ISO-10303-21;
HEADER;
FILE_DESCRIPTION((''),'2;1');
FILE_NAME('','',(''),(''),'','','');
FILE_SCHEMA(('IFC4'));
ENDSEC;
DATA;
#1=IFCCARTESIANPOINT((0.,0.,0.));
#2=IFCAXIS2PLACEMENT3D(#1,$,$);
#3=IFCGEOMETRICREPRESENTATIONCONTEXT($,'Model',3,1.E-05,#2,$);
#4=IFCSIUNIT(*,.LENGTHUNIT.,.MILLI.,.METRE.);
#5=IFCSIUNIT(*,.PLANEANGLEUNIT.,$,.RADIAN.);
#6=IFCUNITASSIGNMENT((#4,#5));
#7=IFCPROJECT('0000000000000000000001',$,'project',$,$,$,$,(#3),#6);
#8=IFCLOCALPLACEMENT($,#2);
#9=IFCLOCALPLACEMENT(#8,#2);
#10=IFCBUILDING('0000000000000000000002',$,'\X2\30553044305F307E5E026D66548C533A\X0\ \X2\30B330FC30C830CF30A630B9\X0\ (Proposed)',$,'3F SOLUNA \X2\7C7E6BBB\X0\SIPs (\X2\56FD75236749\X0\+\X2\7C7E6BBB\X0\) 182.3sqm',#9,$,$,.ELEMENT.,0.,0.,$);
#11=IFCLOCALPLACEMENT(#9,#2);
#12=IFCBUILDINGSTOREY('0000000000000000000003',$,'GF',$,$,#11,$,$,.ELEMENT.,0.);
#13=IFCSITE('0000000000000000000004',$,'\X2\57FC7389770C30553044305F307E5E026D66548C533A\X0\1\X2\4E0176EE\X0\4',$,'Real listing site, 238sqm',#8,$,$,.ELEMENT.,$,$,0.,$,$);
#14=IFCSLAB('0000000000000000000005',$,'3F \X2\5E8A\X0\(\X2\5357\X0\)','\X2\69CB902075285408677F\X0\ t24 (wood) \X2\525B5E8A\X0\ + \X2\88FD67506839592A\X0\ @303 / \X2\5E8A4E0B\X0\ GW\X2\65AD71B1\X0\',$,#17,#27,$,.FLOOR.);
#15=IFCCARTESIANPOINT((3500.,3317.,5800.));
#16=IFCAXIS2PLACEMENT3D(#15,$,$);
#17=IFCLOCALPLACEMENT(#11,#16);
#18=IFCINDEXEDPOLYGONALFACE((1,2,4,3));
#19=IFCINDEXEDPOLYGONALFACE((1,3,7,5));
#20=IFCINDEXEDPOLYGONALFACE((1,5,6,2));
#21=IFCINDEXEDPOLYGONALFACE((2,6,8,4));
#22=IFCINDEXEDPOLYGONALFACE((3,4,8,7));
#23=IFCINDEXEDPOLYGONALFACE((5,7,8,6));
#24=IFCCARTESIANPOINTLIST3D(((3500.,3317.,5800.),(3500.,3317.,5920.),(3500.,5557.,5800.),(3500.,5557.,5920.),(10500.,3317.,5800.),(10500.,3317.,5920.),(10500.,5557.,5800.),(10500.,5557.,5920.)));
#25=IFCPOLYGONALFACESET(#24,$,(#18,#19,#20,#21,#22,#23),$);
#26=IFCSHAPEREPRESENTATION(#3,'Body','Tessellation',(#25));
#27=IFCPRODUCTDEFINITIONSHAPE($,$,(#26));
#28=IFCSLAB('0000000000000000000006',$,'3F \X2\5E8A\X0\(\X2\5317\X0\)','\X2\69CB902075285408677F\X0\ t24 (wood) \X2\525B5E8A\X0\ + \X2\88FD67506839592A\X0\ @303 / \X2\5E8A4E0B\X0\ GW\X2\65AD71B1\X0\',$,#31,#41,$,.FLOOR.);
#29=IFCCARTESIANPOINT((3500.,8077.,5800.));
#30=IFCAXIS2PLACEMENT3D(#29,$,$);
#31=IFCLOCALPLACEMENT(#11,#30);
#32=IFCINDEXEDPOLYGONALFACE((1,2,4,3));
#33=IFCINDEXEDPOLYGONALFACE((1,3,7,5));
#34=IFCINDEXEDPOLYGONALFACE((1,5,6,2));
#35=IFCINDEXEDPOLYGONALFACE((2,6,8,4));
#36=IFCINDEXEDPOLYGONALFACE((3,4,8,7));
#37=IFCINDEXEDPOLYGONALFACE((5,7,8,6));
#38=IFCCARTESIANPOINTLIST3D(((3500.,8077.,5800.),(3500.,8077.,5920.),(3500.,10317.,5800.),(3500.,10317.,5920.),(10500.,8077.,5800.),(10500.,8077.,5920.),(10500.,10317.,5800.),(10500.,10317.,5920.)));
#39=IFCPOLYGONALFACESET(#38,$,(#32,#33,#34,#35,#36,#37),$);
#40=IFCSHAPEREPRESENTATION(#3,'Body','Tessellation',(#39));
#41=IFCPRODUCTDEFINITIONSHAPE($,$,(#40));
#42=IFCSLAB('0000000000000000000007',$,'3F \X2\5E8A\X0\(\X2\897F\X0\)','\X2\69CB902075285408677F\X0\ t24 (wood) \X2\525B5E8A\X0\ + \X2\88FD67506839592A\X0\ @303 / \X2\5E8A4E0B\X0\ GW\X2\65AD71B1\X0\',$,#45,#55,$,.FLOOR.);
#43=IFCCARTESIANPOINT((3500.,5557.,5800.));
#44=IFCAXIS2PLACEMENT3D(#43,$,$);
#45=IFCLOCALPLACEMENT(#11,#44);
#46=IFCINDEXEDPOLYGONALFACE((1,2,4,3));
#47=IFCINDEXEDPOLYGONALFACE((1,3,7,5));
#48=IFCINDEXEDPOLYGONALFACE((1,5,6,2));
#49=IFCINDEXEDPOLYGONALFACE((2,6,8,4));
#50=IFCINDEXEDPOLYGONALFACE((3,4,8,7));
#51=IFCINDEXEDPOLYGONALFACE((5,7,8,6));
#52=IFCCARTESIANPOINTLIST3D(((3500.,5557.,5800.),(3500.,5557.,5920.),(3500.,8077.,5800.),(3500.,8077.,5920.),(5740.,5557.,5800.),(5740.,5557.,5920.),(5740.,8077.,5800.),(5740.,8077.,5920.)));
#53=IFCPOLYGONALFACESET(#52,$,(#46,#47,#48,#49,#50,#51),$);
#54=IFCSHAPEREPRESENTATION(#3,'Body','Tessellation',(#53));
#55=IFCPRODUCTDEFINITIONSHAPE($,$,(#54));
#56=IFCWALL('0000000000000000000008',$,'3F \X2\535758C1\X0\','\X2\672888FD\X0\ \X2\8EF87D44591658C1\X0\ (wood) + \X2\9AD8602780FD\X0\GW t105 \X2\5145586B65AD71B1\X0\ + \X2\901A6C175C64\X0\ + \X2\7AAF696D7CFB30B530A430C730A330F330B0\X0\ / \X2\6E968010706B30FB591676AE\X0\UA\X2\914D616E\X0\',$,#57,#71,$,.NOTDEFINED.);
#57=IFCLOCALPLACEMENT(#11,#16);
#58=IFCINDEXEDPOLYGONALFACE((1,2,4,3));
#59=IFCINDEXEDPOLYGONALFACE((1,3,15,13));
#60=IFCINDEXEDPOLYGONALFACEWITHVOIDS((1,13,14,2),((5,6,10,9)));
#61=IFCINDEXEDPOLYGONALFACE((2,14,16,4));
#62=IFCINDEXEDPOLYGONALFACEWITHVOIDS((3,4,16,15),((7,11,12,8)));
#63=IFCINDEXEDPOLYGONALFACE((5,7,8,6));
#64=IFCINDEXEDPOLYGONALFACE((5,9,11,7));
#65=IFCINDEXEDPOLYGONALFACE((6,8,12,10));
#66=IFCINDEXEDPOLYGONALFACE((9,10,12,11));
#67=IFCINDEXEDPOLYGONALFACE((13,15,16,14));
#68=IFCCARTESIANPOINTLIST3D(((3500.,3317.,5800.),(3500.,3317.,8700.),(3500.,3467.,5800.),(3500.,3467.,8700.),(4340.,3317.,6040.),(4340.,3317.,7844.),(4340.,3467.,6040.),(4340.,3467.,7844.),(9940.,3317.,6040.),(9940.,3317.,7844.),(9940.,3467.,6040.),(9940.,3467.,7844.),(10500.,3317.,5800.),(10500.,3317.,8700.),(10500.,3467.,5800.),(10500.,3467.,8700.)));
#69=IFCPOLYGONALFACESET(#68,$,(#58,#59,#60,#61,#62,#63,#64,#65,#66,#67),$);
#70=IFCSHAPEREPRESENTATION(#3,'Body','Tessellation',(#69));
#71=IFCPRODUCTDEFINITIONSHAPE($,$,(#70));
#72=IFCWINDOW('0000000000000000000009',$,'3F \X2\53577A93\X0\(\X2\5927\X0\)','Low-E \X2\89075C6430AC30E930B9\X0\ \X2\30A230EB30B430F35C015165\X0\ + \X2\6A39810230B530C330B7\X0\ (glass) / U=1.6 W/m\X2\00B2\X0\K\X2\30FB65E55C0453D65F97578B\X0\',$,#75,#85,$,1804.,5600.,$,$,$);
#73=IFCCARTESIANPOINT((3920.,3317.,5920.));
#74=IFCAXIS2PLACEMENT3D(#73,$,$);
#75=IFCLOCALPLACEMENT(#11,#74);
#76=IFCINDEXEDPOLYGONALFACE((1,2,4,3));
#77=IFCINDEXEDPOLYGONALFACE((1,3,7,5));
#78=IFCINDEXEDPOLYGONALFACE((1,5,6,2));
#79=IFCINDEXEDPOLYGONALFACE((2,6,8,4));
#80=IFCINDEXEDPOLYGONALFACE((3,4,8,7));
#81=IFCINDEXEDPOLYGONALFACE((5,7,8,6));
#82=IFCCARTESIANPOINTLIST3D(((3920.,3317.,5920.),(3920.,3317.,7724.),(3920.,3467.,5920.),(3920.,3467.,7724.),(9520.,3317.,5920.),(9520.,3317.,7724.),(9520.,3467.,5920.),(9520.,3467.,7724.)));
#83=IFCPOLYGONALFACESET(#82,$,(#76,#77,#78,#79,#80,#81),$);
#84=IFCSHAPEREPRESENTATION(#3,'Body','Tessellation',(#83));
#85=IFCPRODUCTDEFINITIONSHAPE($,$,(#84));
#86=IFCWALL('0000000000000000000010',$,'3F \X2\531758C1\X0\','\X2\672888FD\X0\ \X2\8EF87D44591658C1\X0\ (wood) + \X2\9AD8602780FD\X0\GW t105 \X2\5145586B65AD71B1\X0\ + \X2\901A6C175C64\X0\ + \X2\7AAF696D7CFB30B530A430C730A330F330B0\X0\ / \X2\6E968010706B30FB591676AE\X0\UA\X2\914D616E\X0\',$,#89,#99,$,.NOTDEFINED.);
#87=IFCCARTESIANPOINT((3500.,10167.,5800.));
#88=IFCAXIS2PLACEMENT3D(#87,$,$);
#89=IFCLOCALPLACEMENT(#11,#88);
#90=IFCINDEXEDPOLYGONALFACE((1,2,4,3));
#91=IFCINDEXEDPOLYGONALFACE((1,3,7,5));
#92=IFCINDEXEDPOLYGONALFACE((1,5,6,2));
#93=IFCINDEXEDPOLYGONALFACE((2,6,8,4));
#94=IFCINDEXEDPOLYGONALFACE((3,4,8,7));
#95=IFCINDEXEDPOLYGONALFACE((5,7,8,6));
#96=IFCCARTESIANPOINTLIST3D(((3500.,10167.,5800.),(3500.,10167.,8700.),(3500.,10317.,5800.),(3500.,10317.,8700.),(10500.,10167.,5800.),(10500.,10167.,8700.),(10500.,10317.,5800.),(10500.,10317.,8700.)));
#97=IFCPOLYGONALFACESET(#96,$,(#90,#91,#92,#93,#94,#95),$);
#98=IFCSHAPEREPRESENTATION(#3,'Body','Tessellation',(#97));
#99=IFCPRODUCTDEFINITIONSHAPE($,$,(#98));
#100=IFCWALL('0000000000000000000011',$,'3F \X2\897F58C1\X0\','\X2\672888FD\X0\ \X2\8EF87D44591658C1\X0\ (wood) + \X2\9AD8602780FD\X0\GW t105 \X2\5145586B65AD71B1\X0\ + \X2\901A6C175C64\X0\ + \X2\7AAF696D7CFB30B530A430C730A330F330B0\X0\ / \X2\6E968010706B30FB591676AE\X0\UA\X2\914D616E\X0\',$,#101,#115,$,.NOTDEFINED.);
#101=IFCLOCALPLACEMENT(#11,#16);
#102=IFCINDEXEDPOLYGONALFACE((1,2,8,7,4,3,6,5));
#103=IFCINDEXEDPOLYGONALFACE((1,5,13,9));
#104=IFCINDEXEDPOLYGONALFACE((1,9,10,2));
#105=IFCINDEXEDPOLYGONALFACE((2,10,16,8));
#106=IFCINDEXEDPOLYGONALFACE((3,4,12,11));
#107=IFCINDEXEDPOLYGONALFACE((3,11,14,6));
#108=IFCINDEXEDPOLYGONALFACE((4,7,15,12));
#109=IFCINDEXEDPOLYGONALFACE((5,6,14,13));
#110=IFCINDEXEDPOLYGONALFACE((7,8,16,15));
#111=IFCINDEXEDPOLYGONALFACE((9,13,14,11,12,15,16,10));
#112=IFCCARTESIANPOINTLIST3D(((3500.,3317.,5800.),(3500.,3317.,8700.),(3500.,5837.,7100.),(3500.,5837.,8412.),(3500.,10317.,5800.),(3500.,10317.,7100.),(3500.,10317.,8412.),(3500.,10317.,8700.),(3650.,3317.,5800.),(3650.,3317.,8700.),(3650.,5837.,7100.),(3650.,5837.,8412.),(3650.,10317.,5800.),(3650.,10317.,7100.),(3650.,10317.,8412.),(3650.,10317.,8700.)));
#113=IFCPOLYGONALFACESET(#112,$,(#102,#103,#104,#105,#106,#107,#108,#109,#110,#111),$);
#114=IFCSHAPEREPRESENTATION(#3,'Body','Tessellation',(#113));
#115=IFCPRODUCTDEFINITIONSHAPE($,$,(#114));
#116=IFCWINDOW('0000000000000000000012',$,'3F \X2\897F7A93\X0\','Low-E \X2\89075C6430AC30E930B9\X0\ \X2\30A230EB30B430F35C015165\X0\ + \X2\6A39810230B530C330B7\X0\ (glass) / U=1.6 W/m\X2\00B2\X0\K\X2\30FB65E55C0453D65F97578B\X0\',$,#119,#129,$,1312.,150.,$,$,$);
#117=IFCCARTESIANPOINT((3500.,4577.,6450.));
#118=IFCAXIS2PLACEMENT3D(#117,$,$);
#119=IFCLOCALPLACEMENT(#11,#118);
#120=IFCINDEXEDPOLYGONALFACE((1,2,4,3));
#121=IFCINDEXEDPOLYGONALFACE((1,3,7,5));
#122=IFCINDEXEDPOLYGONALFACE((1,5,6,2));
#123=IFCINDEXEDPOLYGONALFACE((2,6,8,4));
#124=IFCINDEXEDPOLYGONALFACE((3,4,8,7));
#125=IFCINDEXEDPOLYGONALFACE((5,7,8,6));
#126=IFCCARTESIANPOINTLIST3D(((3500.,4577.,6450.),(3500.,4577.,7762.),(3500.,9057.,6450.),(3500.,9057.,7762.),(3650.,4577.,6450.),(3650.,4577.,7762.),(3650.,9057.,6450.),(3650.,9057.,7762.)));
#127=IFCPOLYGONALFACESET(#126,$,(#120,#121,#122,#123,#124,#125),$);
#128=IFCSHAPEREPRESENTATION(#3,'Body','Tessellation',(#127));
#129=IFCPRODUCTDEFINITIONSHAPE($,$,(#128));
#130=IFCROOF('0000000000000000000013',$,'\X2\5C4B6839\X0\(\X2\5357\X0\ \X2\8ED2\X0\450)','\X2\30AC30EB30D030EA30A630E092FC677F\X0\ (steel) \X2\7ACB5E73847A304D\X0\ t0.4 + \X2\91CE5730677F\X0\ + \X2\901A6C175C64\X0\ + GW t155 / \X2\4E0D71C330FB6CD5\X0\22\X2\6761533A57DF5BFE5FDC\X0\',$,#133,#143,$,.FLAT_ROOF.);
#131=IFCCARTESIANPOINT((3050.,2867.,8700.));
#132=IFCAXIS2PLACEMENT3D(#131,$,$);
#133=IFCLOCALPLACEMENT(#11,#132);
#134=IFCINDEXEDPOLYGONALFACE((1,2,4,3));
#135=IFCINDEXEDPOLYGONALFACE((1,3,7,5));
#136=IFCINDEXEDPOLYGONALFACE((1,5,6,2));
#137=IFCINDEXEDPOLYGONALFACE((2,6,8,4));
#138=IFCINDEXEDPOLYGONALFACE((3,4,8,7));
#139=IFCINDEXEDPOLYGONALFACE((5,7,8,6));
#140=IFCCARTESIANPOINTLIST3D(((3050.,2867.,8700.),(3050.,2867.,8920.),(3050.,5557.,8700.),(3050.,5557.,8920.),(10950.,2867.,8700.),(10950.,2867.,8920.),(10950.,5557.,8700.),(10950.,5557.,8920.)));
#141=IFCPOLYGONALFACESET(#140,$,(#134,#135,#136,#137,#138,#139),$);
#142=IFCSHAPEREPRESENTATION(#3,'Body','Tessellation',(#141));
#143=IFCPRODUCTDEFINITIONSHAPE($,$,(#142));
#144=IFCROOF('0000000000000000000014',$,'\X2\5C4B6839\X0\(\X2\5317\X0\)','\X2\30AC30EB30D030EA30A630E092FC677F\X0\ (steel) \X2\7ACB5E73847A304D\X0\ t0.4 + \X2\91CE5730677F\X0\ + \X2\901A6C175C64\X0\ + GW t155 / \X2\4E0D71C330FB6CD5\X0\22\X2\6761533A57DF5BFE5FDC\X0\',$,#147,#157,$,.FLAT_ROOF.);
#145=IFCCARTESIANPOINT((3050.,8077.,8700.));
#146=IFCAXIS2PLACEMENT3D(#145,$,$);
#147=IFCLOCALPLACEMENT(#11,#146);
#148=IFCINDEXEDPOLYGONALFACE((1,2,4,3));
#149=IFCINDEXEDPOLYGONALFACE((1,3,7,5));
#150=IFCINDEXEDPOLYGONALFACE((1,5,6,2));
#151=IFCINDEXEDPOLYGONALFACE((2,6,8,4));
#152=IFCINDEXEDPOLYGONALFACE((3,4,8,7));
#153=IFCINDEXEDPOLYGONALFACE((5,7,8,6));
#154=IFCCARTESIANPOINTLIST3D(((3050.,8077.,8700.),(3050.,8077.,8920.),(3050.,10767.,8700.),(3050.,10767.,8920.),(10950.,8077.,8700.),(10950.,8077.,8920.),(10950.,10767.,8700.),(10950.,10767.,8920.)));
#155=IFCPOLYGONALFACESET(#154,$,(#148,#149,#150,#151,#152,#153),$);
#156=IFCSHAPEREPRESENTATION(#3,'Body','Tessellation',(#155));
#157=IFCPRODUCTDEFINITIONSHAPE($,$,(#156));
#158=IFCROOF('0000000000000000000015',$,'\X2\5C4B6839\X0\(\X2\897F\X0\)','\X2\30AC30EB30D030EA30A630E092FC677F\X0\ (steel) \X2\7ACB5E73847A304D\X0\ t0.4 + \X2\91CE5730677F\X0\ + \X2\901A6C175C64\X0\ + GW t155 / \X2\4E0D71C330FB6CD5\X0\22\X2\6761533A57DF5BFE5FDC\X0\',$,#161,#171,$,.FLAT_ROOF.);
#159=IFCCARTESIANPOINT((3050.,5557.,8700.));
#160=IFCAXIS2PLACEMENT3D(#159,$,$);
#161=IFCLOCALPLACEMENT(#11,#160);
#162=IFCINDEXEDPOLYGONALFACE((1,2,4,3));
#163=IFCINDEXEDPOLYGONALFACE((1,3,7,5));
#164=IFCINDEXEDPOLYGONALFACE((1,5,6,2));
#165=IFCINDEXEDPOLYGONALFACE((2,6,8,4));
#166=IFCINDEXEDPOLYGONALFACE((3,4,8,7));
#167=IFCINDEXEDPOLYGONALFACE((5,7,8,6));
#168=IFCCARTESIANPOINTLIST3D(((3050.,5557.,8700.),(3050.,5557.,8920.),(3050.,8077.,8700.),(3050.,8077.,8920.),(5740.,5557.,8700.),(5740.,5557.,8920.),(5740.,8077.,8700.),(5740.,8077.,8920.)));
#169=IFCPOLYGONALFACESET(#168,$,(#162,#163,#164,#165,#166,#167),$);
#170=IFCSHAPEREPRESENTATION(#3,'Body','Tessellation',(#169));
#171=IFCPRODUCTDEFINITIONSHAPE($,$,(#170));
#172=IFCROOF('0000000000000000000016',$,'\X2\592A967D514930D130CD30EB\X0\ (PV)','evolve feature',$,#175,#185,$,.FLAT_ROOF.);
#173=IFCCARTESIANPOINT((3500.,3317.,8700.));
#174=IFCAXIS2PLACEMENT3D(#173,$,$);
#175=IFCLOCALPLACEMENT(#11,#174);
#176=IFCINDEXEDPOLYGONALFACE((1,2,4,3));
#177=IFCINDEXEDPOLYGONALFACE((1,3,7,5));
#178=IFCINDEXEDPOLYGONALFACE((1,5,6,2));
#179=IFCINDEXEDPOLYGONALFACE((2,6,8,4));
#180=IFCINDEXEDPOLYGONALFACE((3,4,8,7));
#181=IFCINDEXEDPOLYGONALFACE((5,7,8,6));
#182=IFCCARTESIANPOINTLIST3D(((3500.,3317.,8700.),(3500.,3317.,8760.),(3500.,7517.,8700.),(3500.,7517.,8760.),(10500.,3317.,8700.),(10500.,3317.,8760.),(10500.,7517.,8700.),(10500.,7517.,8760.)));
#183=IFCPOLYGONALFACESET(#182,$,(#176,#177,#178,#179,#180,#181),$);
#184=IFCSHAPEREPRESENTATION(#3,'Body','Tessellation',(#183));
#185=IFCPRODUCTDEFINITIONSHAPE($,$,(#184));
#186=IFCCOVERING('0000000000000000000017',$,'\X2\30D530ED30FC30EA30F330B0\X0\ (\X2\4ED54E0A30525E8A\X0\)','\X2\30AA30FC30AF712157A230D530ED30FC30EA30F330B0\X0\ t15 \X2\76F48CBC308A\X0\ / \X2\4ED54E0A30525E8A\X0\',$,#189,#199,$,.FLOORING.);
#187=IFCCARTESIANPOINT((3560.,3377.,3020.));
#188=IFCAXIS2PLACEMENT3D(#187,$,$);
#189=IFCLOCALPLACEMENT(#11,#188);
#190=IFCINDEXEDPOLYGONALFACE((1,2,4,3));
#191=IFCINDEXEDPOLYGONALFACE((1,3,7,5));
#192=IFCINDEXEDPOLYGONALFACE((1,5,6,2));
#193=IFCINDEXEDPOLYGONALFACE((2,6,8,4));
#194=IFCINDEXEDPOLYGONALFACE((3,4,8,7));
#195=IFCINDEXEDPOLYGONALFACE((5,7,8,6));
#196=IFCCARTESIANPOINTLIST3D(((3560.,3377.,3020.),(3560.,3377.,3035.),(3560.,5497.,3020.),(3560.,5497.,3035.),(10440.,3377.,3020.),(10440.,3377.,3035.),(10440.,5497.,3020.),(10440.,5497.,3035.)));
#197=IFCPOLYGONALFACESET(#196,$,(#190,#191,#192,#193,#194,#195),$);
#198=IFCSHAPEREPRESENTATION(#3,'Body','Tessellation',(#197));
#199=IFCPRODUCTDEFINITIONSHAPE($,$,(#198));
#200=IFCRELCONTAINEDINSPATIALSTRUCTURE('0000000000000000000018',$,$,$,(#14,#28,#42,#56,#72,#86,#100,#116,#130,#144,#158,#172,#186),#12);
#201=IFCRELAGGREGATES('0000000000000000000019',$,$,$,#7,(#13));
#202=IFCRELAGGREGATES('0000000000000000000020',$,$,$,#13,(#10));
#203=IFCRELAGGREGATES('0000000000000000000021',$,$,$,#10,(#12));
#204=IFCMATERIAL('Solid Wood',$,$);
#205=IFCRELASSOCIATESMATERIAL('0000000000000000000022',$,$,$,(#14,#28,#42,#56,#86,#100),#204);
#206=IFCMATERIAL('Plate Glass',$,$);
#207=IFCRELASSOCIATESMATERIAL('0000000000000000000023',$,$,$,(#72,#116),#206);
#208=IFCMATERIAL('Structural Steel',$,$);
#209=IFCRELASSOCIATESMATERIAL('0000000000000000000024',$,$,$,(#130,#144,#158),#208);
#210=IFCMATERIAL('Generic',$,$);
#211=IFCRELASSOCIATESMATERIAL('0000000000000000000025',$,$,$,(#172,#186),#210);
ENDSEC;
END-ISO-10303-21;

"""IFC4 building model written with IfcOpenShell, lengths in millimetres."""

from ifc_helpers import new_model, si_unit, frame, frame_2d, origin, place, context, project, spatial, rectangle, extrude, material, element, fill, save


model = new_model("IFC4")

# Units and contexts
model_context = context("Model", 3, precision=1e-05, world=origin())
ifc_project = project(units=[si_unit("LENGTHUNIT", "METRE", prefix="MILLI"), si_unit("PLANEANGLEUNIT", "RADIAN")], contexts=[model_context])

# Site, building, storey
site_placement = place(None, origin())
site = spatial("IfcSite", under=ifc_project, at=site_placement, Name="埼玉県さいたま市浦和区1丁目4", ObjectType="Real listing site, 238sqm", CompositionType="ELEMENT", RefElevation=0.0)
building_placement = place(site_placement, origin())
building = spatial("IfcBuilding", under=site, at=building_placement, Name="さいたま市浦和区 コートハウス (Proposed)", ObjectType="3F SOLUNA 籾殻SIPs (国産杉+籾殻) 182.3sqm", CompositionType="ELEMENT", ElevationOfRefHeight=0.0, ElevationOfTerrain=0.0)
storey_placement = place(building_placement, origin())
storey = spatial("IfcBuildingStorey", under=building, at=storey_placement, Name="GF", CompositionType="ELEMENT", Elevation=0.0)

# Slabs
ifc_material_1 = material(Name="Solid Wood")
slab_1_placement = place(storey_placement, frame((3500.0, 3317.0, 5800.0)))
element("IfcSlab", 1, at=slab_1_placement, inside=storey, material=ifc_material_1, Name="3F 床(南)", Description="構造用合板 t24 (wood) 剛床 + 製材根太 @303 / 床下 GW断熱", PredefinedType="FLOOR", context=model_context, shape_type="SweptSolid", body=[
    extrude(rectangle(XDim=7000.0, YDim=2240.0, at=frame_2d((3500.0, 1120.0))), frame((3500.0, 3317.0, 5800.0)), (0.0, 0.0, 1.0), 120.0),
])
slab_2_placement = place(storey_placement, frame((3500.0, 8077.0, 5800.0)))
element("IfcSlab", 2, at=slab_2_placement, inside=storey, material=ifc_material_1, Name="3F 床(北)", Description="構造用合板 t24 (wood) 剛床 + 製材根太 @303 / 床下 GW断熱", PredefinedType="FLOOR", context=model_context, shape_type="SweptSolid", body=[
    extrude(rectangle(XDim=7000.0, YDim=2240.0, at=frame_2d((3500.0, 1120.0))), frame((3500.0, 8077.0, 5800.0)), (0.0, 0.0, 1.0), 120.0),
])
slab_3_placement = place(storey_placement, frame((3500.0, 5557.0, 5800.0)))
element("IfcSlab", 3, at=slab_3_placement, inside=storey, material=ifc_material_1, Name="3F 床(西)", Description="構造用合板 t24 (wood) 剛床 + 製材根太 @303 / 床下 GW断熱", PredefinedType="FLOOR", context=model_context, shape_type="SweptSolid", body=[
    extrude(rectangle(XDim=2240.0, YDim=2520.0, at=frame_2d((1120.0, 1260.0))), frame((3500.0, 5557.0, 5800.0)), (0.0, 0.0, 1.0), 120.0),
])

# Wall, opening, window
wall_1_placement = place(storey_placement, frame((3500.0, 3317.0, 5800.0)))
wall_1 = element("IfcWall", 4, at=wall_1_placement, inside=storey, material=ifc_material_1, Name="3F 南壁", Description="木製 軸組外壁 (wood) + 高性能GW t105 充填断熱 + 通気層 + 窯業系サイディング / 準耐火・外皮UA配慮", PredefinedType="NOTDEFINED", context=model_context, shape_type="SweptSolid", body=[
    extrude(rectangle(XDim=7000.0, YDim=150.0, at=frame_2d((3500.0, 75.0))), frame((3500.0, 3317.0, 5800.0)), (0.0, 0.0, 1.0), 2900.0),
])
opening_1_placement = place(storey_placement, frame((3920.0, 3317.0, 5920.0)))
opening_1 = element("IfcOpeningElement", 5, at=opening_1_placement, cuts=wall_1, PredefinedType="NOTDEFINED", context=model_context, shape_type="SweptSolid", body=[
    extrude(rectangle(XDim=5600.0, YDim=150.0, at=frame_2d((2800.0, 75.0))), frame((3920.0, 3317.0, 5920.0)), (0.0, 0.0, 1.0), 1804.0),
])
ifc_material_2 = material(Name="Plate Glass")
window_1_placement = place(storey_placement, frame((3920.0, 3317.0, 5920.0)))
window_1 = element("IfcWindow", 6, at=window_1_placement, inside=storey, material=ifc_material_2, Name="3F 南窓(大)", Description="Low-E 複層ガラス アルゴン封入 + 樹脂サッシ (glass) / U=1.6 W/m²K・日射取得型", OverallHeight=1804.0, OverallWidth=5600.0, context=model_context, shape_type="SweptSolid", body=[
    extrude(rectangle(XDim=5600.0, YDim=150.0, at=frame_2d((2800.0, 75.0))), frame((3920.0, 3317.0, 5920.0)), (0.0, 0.0, 1.0), 1804.0),
])
fill(opening_1, window_1)

# Wall
wall_2_placement = place(storey_placement, frame((3500.0, 10167.0, 5800.0)))
element("IfcWall", 7, at=wall_2_placement, inside=storey, material=ifc_material_1, Name="3F 北壁", Description="木製 軸組外壁 (wood) + 高性能GW t105 充填断熱 + 通気層 + 窯業系サイディング / 準耐火・外皮UA配慮", PredefinedType="NOTDEFINED", context=model_context, shape_type="SweptSolid", body=[
    extrude(rectangle(XDim=7000.0, YDim=150.0, at=frame_2d((3500.0, 75.0))), frame((3500.0, 10167.0, 5800.0)), (0.0, 0.0, 1.0), 2900.0),
])

# Wall, opening, window
wall_3_placement = place(storey_placement, frame((3500.0, 3317.0, 5800.0)))
wall_3 = element("IfcWall", 8, at=wall_3_placement, inside=storey, material=ifc_material_1, Name="3F 西壁", Description="木製 軸組外壁 (wood) + 高性能GW t105 充填断熱 + 通気層 + 窯業系サイディング / 準耐火・外皮UA配慮", PredefinedType="NOTDEFINED", context=model_context, shape_type="SweptSolid", body=[
    extrude(rectangle(XDim=150.0, YDim=7000.0, at=frame_2d((75.0, 3500.0))), frame((3500.0, 3317.0, 5800.0)), (0.0, 0.0, 1.0), 2900.0),
])
opening_2_placement = place(storey_placement, frame((3500.0, 4577.0, 6450.0)))
opening_2 = element("IfcOpeningElement", 9, at=opening_2_placement, cuts=wall_3, PredefinedType="NOTDEFINED", context=model_context, shape_type="SweptSolid", body=[
    extrude(rectangle(XDim=150.0, YDim=4480.0, at=frame_2d((75.0, 2240.0))), frame((3500.0, 4577.0, 6450.0)), (0.0, 0.0, 1.0), 1312.0),
])
window_2_placement = place(storey_placement, frame((3500.0, 4577.0, 6450.0)))
window_2 = element("IfcWindow", 10, at=window_2_placement, inside=storey, material=ifc_material_2, Name="3F 西窓", Description="Low-E 複層ガラス アルゴン封入 + 樹脂サッシ (glass) / U=1.6 W/m²K・日射取得型", OverallHeight=1312.0, OverallWidth=150.0, context=model_context, shape_type="SweptSolid", body=[
    extrude(rectangle(XDim=150.0, YDim=4480.0, at=frame_2d((75.0, 2240.0))), frame((3500.0, 4577.0, 6450.0)), (0.0, 0.0, 1.0), 1312.0),
])
fill(opening_2, window_2)

# Roofs
ifc_material_3 = material(Name="Structural Steel")
roof_1_placement = place(storey_placement, frame((3050.0, 2867.0, 8700.0)))
element("IfcRoof", 11, at=roof_1_placement, inside=storey, material=ifc_material_3, Name="屋根(南 軒450)", Description="ガルバリウム鋼板 (steel) 立平葺き t0.4 + 野地板 + 通気層 + GW t155 / 不燃・法22条区域対応", PredefinedType="FLAT_ROOF", context=model_context, shape_type="SweptSolid", body=[
    extrude(rectangle(XDim=7900.0, YDim=2690.0, at=frame_2d((3950.0, 1345.0))), frame((3050.0, 2867.0, 8700.0)), (0.0, 0.0, 1.0), 220.0),
])
roof_2_placement = place(storey_placement, frame((3050.0, 8077.0, 8700.0)))
element("IfcRoof", 12, at=roof_2_placement, inside=storey, material=ifc_material_3, Name="屋根(北)", Description="ガルバリウム鋼板 (steel) 立平葺き t0.4 + 野地板 + 通気層 + GW t155 / 不燃・法22条区域対応", PredefinedType="FLAT_ROOF", context=model_context, shape_type="SweptSolid", body=[
    extrude(rectangle(XDim=7900.0, YDim=2690.0, at=frame_2d((3950.0, 1345.0))), frame((3050.0, 8077.0, 8700.0)), (0.0, 0.0, 1.0), 220.0),
])
roof_3_placement = place(storey_placement, frame((3050.0, 5557.0, 8700.0)))
element("IfcRoof", 13, at=roof_3_placement, inside=storey, material=ifc_material_3, Name="屋根(西)", Description="ガルバリウム鋼板 (steel) 立平葺き t0.4 + 野地板 + 通気層 + GW t155 / 不燃・法22条区域対応", PredefinedType="FLAT_ROOF", context=model_context, shape_type="SweptSolid", body=[
    extrude(rectangle(XDim=2690.0, YDim=2520.0, at=frame_2d((1345.0, 1260.0))), frame((3050.0, 5557.0, 8700.0)), (0.0, 0.0, 1.0), 220.0),
])
ifc_material_4 = material(Name="Generic")
roof_4_placement = place(storey_placement, frame((3500.0, 3317.0, 8700.0)))
element("IfcRoof", 14, at=roof_4_placement, inside=storey, material=ifc_material_4, Name="太陽光パネル (PV)", Description="evolve feature", PredefinedType="FLAT_ROOF", context=model_context, shape_type="SweptSolid", body=[
    extrude(rectangle(XDim=7000.0, YDim=4200.0, at=frame_2d((3500.0, 2100.0))), frame((3500.0, 3317.0, 8700.0)), (0.0, 0.0, 1.0), 60.0),
])

# Covering
covering_1_placement = place(storey_placement, frame((3560.0, 3377.0, 3020.0)))
element("IfcCovering", 15, at=covering_1_placement, inside=storey, material=ifc_material_4, Name="フローリング (仕上げ床)", Description="オーク無垢フローリング t15 直貼り / 仕上げ床", PredefinedType="FLOORING", context=model_context, shape_type="SweptSolid", body=[
    extrude(rectangle(XDim=6880.0, YDim=2120.0, at=frame_2d((3440.0, 1060.0))), frame((3560.0, 3377.0, 3020.0)), (0.0, 0.0, 1.0), 15.0),
])

save(model, "model.ifc")
